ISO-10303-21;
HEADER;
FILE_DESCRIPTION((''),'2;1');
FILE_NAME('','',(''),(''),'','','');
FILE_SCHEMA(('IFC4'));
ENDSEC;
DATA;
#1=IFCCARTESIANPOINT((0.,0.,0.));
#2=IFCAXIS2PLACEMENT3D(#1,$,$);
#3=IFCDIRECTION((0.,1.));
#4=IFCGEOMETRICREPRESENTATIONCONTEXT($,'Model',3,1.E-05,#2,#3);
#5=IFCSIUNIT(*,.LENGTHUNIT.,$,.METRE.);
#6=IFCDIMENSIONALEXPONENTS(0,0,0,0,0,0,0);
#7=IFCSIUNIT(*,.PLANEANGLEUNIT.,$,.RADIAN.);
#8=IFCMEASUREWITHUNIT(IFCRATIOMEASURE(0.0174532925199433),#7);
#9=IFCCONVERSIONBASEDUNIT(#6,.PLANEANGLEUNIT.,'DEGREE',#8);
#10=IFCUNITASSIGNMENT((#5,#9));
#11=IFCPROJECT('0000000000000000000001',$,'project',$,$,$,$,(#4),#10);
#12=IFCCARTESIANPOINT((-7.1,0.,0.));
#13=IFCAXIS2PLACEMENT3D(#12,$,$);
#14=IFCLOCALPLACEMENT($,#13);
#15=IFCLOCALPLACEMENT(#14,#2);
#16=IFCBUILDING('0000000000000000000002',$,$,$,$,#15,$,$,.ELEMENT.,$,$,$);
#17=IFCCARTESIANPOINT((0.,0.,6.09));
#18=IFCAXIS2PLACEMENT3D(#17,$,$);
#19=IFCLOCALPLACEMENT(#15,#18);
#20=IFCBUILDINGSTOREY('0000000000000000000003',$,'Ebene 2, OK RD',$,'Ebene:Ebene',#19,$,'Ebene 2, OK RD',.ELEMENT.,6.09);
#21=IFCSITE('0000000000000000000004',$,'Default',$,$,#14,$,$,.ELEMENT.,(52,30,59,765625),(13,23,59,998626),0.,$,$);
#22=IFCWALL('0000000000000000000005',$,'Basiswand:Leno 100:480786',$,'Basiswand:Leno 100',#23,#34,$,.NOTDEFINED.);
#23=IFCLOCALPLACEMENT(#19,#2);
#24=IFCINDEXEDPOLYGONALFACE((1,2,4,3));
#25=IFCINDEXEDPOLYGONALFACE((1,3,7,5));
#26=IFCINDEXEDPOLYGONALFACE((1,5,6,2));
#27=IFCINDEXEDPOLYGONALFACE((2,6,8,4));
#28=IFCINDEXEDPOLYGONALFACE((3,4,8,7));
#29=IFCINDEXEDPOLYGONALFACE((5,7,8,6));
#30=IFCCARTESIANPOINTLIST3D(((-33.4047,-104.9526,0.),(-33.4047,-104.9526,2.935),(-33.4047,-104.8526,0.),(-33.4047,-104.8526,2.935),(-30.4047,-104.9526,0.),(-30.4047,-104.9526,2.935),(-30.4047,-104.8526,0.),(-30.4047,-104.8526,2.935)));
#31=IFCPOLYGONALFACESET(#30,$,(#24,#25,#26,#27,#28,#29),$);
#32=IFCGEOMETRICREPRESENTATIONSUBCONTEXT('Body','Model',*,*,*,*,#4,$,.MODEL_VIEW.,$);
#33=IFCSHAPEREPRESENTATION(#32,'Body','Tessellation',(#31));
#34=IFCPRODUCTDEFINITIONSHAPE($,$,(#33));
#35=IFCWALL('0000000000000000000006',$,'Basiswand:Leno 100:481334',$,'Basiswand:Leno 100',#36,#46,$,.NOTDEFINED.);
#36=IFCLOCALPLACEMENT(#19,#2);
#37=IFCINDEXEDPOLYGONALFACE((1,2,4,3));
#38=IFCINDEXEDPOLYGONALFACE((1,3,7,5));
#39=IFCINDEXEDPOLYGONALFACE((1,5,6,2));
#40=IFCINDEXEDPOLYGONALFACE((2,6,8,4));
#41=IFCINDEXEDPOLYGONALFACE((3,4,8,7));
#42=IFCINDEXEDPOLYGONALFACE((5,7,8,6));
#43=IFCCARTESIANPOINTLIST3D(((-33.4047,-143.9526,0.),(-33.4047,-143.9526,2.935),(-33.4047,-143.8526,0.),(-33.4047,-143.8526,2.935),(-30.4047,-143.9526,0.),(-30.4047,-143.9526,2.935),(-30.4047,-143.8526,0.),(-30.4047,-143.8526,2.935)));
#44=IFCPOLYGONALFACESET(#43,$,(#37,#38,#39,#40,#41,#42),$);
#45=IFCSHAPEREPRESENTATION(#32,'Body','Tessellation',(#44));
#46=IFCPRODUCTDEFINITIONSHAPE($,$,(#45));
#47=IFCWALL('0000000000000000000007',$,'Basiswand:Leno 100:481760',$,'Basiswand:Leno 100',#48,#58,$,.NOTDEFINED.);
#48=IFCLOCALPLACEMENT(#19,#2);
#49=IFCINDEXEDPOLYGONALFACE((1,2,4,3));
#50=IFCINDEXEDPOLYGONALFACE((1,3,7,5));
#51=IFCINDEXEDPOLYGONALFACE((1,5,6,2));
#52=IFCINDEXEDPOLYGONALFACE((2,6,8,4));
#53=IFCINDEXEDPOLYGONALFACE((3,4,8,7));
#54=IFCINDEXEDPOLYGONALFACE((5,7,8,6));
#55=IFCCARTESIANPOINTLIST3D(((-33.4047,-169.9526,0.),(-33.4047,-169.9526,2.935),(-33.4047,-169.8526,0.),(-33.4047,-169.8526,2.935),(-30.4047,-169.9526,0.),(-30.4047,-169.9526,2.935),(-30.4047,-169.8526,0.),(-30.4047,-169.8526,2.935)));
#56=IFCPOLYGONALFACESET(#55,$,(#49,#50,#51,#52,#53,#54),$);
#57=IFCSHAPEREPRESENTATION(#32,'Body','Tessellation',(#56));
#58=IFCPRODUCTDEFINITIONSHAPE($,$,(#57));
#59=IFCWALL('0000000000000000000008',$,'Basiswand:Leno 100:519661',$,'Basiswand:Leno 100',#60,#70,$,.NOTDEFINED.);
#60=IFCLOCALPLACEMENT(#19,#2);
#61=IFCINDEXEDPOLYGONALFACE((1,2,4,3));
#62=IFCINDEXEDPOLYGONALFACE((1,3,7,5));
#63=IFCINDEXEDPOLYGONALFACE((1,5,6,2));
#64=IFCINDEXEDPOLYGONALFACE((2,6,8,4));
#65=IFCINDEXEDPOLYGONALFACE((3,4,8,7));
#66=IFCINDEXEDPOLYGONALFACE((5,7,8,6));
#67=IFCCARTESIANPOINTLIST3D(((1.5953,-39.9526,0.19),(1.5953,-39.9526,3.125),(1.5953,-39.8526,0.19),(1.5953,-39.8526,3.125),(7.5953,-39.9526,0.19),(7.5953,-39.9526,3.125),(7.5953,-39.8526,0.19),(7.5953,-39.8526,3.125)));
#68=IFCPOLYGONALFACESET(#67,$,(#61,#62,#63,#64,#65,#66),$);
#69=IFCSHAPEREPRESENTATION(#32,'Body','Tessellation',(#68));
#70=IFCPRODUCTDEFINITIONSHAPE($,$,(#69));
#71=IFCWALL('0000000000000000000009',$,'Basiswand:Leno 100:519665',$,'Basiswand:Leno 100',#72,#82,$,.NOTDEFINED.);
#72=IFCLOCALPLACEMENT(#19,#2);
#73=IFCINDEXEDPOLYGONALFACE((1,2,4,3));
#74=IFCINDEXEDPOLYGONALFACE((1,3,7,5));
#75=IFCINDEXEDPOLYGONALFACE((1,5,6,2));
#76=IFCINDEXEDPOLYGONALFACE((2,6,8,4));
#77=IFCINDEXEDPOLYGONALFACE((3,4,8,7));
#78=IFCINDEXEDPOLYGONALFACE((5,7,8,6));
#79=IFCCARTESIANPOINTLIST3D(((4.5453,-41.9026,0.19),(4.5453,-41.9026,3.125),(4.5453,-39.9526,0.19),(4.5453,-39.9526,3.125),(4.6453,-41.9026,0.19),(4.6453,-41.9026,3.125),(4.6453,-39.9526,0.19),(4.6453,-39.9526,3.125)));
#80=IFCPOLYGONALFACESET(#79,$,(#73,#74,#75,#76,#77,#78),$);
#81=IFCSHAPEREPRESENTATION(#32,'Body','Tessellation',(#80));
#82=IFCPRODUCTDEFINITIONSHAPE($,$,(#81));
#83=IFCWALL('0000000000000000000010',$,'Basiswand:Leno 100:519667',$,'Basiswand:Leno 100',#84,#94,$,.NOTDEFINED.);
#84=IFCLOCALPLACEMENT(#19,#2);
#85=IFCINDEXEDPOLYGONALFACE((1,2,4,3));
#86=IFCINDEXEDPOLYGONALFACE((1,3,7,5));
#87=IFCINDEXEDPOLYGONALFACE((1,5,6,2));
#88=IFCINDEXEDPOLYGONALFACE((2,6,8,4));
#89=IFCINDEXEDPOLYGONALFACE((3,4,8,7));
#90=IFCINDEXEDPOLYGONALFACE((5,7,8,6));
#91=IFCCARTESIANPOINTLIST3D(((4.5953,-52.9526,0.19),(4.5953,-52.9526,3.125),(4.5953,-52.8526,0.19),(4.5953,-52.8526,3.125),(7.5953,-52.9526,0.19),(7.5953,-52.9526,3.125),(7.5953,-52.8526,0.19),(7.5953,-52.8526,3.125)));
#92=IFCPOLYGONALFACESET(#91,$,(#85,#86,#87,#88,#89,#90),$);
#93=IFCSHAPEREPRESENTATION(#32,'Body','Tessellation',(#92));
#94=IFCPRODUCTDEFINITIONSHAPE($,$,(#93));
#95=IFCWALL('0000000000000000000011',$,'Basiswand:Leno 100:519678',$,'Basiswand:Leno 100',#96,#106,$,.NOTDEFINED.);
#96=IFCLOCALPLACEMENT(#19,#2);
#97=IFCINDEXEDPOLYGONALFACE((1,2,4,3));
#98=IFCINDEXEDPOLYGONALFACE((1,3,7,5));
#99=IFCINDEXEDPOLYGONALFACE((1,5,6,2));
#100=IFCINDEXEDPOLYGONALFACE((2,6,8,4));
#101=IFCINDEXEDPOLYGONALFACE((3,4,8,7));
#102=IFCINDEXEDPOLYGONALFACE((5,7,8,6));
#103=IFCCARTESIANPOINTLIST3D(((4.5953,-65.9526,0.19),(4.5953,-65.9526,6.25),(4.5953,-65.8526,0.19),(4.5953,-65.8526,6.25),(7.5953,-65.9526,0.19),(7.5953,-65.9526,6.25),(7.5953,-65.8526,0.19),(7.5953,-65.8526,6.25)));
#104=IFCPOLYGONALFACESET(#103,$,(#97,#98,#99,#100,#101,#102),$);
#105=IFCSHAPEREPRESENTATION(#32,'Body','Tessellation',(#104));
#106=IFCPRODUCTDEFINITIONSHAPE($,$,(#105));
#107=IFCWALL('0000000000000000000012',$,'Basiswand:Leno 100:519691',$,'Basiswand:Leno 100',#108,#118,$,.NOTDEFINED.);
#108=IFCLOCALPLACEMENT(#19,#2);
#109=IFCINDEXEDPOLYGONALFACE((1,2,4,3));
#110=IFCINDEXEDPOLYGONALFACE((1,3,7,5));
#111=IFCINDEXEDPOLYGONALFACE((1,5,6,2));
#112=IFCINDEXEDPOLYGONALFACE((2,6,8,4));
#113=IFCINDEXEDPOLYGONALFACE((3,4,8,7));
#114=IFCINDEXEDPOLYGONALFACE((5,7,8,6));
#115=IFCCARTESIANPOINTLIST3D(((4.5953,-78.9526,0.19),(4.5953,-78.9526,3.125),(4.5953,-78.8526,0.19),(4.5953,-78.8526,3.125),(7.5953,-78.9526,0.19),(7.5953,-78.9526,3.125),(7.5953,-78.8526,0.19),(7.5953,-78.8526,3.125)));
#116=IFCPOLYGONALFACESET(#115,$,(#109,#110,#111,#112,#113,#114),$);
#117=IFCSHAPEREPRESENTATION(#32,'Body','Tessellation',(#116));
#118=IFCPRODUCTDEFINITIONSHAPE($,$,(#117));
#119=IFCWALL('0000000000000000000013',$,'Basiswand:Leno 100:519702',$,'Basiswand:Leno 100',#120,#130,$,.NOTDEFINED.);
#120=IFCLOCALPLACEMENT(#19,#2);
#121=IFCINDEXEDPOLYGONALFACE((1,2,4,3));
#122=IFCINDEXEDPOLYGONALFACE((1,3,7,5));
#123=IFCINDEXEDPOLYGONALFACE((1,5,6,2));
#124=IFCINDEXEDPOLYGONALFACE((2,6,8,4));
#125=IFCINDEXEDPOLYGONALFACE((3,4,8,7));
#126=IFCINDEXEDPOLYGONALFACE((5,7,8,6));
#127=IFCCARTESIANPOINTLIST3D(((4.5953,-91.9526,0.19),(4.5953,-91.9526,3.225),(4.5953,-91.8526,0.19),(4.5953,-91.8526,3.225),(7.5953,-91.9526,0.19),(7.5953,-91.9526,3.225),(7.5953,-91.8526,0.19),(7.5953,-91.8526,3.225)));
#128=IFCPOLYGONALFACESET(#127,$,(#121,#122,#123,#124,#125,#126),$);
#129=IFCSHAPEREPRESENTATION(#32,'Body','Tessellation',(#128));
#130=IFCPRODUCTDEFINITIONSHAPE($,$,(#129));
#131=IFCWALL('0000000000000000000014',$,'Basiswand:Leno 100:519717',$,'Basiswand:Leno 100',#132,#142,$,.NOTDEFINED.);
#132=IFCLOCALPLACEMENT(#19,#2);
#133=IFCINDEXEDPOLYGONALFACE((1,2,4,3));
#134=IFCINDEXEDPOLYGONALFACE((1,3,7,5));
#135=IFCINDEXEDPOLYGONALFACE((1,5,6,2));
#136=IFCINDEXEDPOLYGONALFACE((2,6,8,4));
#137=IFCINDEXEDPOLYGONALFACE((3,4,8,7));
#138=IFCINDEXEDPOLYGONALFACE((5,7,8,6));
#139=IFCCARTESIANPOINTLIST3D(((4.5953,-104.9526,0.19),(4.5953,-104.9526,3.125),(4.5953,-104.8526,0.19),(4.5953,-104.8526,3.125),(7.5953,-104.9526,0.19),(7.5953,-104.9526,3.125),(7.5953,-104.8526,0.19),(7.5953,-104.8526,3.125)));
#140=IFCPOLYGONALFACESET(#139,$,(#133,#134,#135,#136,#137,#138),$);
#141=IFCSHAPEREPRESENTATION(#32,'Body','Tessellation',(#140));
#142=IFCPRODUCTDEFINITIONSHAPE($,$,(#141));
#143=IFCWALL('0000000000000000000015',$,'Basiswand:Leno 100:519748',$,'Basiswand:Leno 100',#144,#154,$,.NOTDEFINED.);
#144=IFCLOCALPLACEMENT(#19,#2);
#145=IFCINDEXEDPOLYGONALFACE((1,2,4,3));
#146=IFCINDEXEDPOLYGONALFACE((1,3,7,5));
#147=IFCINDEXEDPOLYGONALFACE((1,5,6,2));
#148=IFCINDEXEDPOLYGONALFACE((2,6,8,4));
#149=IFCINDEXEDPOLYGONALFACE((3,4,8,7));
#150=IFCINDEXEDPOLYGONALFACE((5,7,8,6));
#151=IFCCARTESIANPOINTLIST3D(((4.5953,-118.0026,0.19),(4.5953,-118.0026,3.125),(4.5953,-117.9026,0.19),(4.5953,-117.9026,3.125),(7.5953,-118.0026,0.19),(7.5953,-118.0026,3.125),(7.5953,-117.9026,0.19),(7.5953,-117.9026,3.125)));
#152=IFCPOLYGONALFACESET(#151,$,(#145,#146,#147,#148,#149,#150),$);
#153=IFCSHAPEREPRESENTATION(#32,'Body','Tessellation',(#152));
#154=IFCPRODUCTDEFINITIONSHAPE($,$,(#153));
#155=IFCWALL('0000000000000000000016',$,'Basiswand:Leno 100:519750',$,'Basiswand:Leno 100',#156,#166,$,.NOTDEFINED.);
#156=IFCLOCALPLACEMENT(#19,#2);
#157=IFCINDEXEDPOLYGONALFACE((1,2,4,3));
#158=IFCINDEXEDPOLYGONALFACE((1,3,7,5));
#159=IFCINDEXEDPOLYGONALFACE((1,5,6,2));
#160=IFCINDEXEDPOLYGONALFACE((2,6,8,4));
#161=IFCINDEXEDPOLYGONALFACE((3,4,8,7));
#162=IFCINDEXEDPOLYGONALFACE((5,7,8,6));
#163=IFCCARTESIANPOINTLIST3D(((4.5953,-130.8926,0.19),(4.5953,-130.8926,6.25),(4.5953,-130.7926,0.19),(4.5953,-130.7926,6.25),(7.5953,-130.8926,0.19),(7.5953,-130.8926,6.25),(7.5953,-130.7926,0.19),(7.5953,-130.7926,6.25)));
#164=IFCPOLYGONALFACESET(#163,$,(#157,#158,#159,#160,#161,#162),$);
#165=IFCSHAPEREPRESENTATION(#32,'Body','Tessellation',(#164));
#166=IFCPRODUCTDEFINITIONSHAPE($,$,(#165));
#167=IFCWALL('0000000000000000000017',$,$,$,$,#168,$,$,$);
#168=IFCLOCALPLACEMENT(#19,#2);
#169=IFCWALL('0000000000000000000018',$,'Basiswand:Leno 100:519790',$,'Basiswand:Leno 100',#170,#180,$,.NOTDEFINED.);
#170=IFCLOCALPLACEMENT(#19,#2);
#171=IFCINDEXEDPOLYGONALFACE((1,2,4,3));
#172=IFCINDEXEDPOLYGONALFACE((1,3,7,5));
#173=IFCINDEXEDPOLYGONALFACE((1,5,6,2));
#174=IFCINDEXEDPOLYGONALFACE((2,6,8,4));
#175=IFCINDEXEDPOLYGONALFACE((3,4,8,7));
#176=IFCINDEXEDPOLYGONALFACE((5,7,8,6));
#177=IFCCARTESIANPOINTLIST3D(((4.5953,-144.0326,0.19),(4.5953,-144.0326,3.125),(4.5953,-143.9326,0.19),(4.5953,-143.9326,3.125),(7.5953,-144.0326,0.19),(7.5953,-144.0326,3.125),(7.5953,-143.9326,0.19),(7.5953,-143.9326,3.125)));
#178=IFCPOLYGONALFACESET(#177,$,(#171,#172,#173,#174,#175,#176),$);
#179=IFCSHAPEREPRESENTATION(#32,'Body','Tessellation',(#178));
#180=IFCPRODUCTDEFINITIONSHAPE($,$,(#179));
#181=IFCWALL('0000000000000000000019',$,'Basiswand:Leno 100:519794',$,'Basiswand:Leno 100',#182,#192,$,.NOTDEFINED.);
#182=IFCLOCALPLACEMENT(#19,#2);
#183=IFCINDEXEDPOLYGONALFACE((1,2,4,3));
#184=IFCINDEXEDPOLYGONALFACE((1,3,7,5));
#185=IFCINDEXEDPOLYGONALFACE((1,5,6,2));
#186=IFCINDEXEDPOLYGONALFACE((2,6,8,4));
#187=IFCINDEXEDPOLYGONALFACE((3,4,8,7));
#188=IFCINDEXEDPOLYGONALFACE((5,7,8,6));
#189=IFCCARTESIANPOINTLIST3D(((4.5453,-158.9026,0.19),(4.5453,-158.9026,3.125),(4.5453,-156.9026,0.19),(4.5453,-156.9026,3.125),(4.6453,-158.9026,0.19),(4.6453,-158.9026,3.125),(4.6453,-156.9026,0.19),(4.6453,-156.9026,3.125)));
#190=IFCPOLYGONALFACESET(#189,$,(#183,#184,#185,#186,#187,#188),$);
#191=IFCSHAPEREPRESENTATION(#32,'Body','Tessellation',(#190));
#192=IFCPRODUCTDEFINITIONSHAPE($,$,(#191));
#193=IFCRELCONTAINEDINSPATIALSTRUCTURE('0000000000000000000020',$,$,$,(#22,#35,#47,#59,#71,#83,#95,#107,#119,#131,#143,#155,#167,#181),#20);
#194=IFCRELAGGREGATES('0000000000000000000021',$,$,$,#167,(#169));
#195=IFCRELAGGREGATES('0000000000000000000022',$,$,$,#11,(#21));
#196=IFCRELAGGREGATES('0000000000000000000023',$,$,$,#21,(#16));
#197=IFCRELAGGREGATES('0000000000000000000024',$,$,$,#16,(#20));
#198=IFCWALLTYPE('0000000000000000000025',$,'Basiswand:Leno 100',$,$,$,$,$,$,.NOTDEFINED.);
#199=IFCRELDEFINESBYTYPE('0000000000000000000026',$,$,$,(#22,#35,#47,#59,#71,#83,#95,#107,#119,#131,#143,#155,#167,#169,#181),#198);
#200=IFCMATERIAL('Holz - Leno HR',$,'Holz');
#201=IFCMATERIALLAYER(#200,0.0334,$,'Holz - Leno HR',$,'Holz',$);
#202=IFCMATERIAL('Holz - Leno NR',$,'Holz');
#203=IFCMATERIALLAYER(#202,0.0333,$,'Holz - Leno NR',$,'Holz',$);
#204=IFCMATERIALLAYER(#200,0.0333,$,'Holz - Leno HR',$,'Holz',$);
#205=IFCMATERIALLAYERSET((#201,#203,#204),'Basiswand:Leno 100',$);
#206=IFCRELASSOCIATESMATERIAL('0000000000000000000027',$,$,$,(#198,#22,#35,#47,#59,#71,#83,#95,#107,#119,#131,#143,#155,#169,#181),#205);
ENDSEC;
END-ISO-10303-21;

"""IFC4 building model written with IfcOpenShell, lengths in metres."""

from ifc_helpers import new_model, entity, si_unit, converted_unit, direction, frame, origin, place, context, subcontext, project, spatial, indexed_curve, outline, extrude, material, layer, layer_set, type_object, element, aggregate, save


model = new_model("IFC4")

# Units and contexts
model_context = context("Model", 3, precision=1e-05, world=origin(), true_north=direction((0.0, 1.0)))
body_context = subcontext(model_context, "Body", "Model", "MODEL_VIEW")
ifc_project = project(units=[si_unit("LENGTHUNIT", "METRE"), converted_unit("PLANEANGLEUNIT", "DEGREE", entity("IfcRatioMeasure", 0.0174532925199433), si_unit("PLANEANGLEUNIT", "RADIAN"), dimensions=[0, 0, 0, 0, 0, 0, 0])], contexts=[model_context])

# Site, building, storey
site_placement = place(None, frame((-7.1, 0.0, 0.0)))
site = spatial("IfcSite", under=ifc_project, at=site_placement, Name="Default", CompositionType="ELEMENT", RefLatitude=(52, 30, 59, 765625), RefLongitude=(13, 23, 59, 998626), RefElevation=0.0)
building_placement = place(site_placement, origin())
building = spatial("IfcBuilding", under=site, at=building_placement, CompositionType="ELEMENT")
storey_placement = place(building_placement, frame((0.0, 0.0, 6.09)))
storey = spatial("IfcBuildingStorey", under=building, at=storey_placement, Name="Ebene 2, OK RD", ObjectType="Ebene:Ebene", LongName="Ebene 2, OK RD", CompositionType="ELEMENT", Elevation=6.09)

# Walls
ifc_material_1 = material(Name="Holz - Leno HR", Category="Holz")
ifc_layer_1 = layer(ifc_material_1, 0.0334, Name="Holz - Leno HR", Category="Holz")
ifc_material_2 = material(Name="Holz - Leno NR", Category="Holz")
ifc_layer_2 = layer(ifc_material_2, 0.0333, Name="Holz - Leno NR", Category="Holz")
ifc_layer_3 = layer(ifc_material_1, 0.0333, Name="Holz - Leno HR", Category="Holz")
ifc_layer_set = layer_set([ifc_layer_1, ifc_layer_2, ifc_layer_3], Name="Basiswand:Leno 100")
wall_type = type_object("IfcWallType", Name="Basiswand:Leno 100", PredefinedType="NOTDEFINED", material=ifc_layer_set)
for number, where, z_axis, x_axis, name in (
    (1, (-30.4047, -104.9026, 0.0), (0.0, 0.0, 1.0), (-1.0, 0.0, 0.0), "Basiswand:Leno 100:480786"),
    (2, (-30.4047, -143.9026, 0.0), (0.0, 0.0, 1.0), (-1.0, 0.0, 0.0), "Basiswand:Leno 100:481334"),
):
    element("IfcWall", number, at=place(storey_placement, frame(where, z_axis=z_axis, x_axis=x_axis)), inside=storey, type_object=wall_type, material=ifc_layer_set, Name=name, ObjectType="Basiswand:Leno 100", PredefinedType="NOTDEFINED", context=body_context, shape_type="SweptSolid", body=[
        extrude(outline(indexed_curve([(3.0, 0.05), (0.0, 0.05), (0.0, -0.05), (3.0, -0.05), (3.0, 0.05)], self_intersect=False)), origin(), (0.0, 0.0, 1.0), 2.935),
    ])
wall_1_placement = place(storey_placement, frame((-30.4047, -169.9026, 0.0), z_axis=(0.0, 0.0, 1.0), x_axis=(-1.0, 0.0, 0.0)))
element("IfcWall", 3, at=wall_1_placement, inside=storey, type_object=wall_type, material=ifc_layer_set, Name="Basiswand:Leno 100:481760", ObjectType="Basiswand:Leno 100", PredefinedType="NOTDEFINED", context=body_context, shape_type="SweptSolid", body=[
    extrude(outline(indexed_curve([(3.0, 0.05), (0.0, 0.05), (0.0, -0.05), (3.0, -0.05), (3.0, 0.05)], self_intersect=False)), origin(), (0.0, 0.0, 1.0), 2.935),
])
wall_2_placement = place(storey_placement, frame((1.5953, -39.9026, 0.19)))
element("IfcWall", 4, at=wall_2_placement, inside=storey, type_object=wall_type, material=ifc_layer_set, Name="Basiswand:Leno 100:519661", ObjectType="Basiswand:Leno 100", PredefinedType="NOTDEFINED", context=body_context, shape_type="SweptSolid", body=[
    extrude(outline(indexed_curve([(6.0, 0.05), (0.0, 0.05), (0.0, -0.05), (6.0, -0.05), (6.0, 0.05)], self_intersect=False)), origin(), (0.0, 0.0, 1.0), 2.935),
])
wall_3_placement = place(storey_placement, frame((4.5953, -41.9026, 0.19), z_axis=(0.0, 0.0, 1.0), x_axis=(0.0, 1.0, 0.0)))
element("IfcWall", 5, at=wall_3_placement, inside=storey, type_object=wall_type, material=ifc_layer_set, Name="Basiswand:Leno 100:519665", ObjectType="Basiswand:Leno 100", PredefinedType="NOTDEFINED", context=body_context, shape_type="SweptSolid", body=[
    extrude(outline(indexed_curve([(1.95, 0.05), (0.0, 0.05), (0.0, -0.05), (1.95, -0.05), (1.95, 0.05)], self_intersect=False)), origin(), (0.0, 0.0, 1.0), 2.935),
])
wall_4_placement = place(storey_placement, frame((7.5953, -52.9026, 0.19), z_axis=(0.0, 0.0, 1.0), x_axis=(-1.0, 0.0, 0.0)))
element("IfcWall", 6, at=wall_4_placement, inside=storey, type_object=wall_type, material=ifc_layer_set, Name="Basiswand:Leno 100:519667", ObjectType="Basiswand:Leno 100", PredefinedType="NOTDEFINED", context=body_context, shape_type="SweptSolid", body=[
    extrude(outline(indexed_curve([(3.0, 0.05), (0.0, 0.05), (0.0, -0.05), (3.0, -0.05), (3.0, 0.05)], self_intersect=False)), origin(), (0.0, 0.0, 1.0), 2.935),
])
wall_5_placement = place(storey_placement, frame((7.5953, -65.9026, 0.19), z_axis=(0.0, 0.0, 1.0), x_axis=(-1.0, 0.0, 0.0)))
element("IfcWall", 7, at=wall_5_placement, inside=storey, type_object=wall_type, material=ifc_layer_set, Name="Basiswand:Leno 100:519678", ObjectType="Basiswand:Leno 100", PredefinedType="NOTDEFINED", context=body_context, shape_type="SweptSolid", body=[
    extrude(outline(indexed_curve([(3.0, 0.05), (0.0, 0.05), (0.0, -0.05), (3.0, -0.05), (3.0, 0.05)], self_intersect=False)), origin(), (0.0, 0.0, 1.0), 6.06),
])
wall_6_placement = place(storey_placement, frame((7.5953, -78.9026, 0.19), z_axis=(0.0, 0.0, 1.0), x_axis=(-1.0, 0.0, 0.0)))
element("IfcWall", 8, at=wall_6_placement, inside=storey, type_object=wall_type, material=ifc_layer_set, Name="Basiswand:Leno 100:519691", ObjectType="Basiswand:Leno 100", PredefinedType="NOTDEFINED", context=body_context, shape_type="SweptSolid", body=[
    extrude(outline(indexed_curve([(3.0, 0.05), (0.0, 0.05), (0.0, -0.05), (3.0, -0.05), (3.0, 0.05)], self_intersect=False)), origin(), (0.0, 0.0, 1.0), 2.935),
])
wall_7_placement = place(storey_placement, frame((7.5953, -91.9026, 0.19), z_axis=(0.0, 0.0, 1.0), x_axis=(-1.0, 0.0, 0.0)))
element("IfcWall", 9, at=wall_7_placement, inside=storey, type_object=wall_type, material=ifc_layer_set, Name="Basiswand:Leno 100:519702", ObjectType="Basiswand:Leno 100", PredefinedType="NOTDEFINED", context=body_context, shape_type="SweptSolid", body=[
    extrude(outline(indexed_curve([(3.0, 0.05), (0.0, 0.05), (0.0, -0.05), (3.0, -0.05), (3.0, 0.05)], self_intersect=False)), origin(), (0.0, 0.0, 1.0), 3.035),
])
for number, where, z_axis, x_axis, name in (
    (10, (7.5953, -104.9026, 0.19), (0.0, 0.0, 1.0), (-1.0, 0.0, 0.0), "Basiswand:Leno 100:519717"),
    (11, (7.5953, -117.9526, 0.19), (0.0, 0.0, 1.0), (-1.0, 0.0, 0.0), "Basiswand:Leno 100:519748"),
):
    element("IfcWall", number, at=place(storey_placement, frame(where, z_axis=z_axis, x_axis=x_axis)), inside=storey, type_object=wall_type, material=ifc_layer_set, Name=name, ObjectType="Basiswand:Leno 100", PredefinedType="NOTDEFINED", context=body_context, shape_type="SweptSolid", body=[
        extrude(outline(indexed_curve([(3.0, 0.05), (0.0, 0.05), (0.0, -0.05), (3.0, -0.05), (3.0, 0.05)], self_intersect=False)), origin(), (0.0, 0.0, 1.0), 2.935),
    ])
wall_8_placement = place(storey_placement, frame((7.5953, -130.8426, 0.19), z_axis=(0.0, 0.0, 1.0), x_axis=(-1.0, 0.0, 0.0)))
element("IfcWall", 12, at=wall_8_placement, inside=storey, type_object=wall_type, material=ifc_layer_set, Name="Basiswand:Leno 100:519750", ObjectType="Basiswand:Leno 100", PredefinedType="NOTDEFINED", context=body_context, shape_type="SweptSolid", body=[
    extrude(outline(indexed_curve([(3.0, 0.05), (0.0, 0.05), (0.0, -0.05), (3.0, -0.05), (3.0, 0.05)], self_intersect=False)), origin(), (0.0, 0.0, 1.0), 6.06),
])
wall_9 = element("IfcWall", 13, inside=storey, type_object=wall_type)
wall_10_placement = place(storey_placement, frame((7.5953, -143.9826, 0.19), z_axis=(0.0, 0.0, 1.0), x_axis=(-1.0, 0.0, 0.0)))
wall_10 = element("IfcWall", 14, at=wall_10_placement, type_object=wall_type, material=ifc_layer_set, Name="Basiswand:Leno 100:519790", ObjectType="Basiswand:Leno 100", PredefinedType="NOTDEFINED", context=body_context, shape_type="SweptSolid", body=[
    extrude(outline(indexed_curve([(3.0, 0.05), (0.0, 0.05), (0.0, -0.05), (3.0, -0.05), (3.0, 0.05)], self_intersect=False)), origin(), (0.0, 0.0, 1.0), 2.935),
])
wall_11_placement = place(storey_placement, frame((4.5953, -158.9026, 0.19), z_axis=(0.0, 0.0, 1.0), x_axis=(0.0, 1.0, 0.0)))
element("IfcWall", 15, at=wall_11_placement, inside=storey, type_object=wall_type, material=ifc_layer_set, Name="Basiswand:Leno 100:519794", ObjectType="Basiswand:Leno 100", PredefinedType="NOTDEFINED", context=body_context, shape_type="SweptSolid", body=[
    extrude(outline(indexed_curve([(2.0, 0.05), (0.0, 0.05), (0.0, -0.05), (2.0, -0.05), (2.0, 0.05)], self_intersect=False)), origin(), (0.0, 0.0, 1.0), 2.935),
])

aggregate(wall_9, [wall_10])

save(model, "model.ifc")
